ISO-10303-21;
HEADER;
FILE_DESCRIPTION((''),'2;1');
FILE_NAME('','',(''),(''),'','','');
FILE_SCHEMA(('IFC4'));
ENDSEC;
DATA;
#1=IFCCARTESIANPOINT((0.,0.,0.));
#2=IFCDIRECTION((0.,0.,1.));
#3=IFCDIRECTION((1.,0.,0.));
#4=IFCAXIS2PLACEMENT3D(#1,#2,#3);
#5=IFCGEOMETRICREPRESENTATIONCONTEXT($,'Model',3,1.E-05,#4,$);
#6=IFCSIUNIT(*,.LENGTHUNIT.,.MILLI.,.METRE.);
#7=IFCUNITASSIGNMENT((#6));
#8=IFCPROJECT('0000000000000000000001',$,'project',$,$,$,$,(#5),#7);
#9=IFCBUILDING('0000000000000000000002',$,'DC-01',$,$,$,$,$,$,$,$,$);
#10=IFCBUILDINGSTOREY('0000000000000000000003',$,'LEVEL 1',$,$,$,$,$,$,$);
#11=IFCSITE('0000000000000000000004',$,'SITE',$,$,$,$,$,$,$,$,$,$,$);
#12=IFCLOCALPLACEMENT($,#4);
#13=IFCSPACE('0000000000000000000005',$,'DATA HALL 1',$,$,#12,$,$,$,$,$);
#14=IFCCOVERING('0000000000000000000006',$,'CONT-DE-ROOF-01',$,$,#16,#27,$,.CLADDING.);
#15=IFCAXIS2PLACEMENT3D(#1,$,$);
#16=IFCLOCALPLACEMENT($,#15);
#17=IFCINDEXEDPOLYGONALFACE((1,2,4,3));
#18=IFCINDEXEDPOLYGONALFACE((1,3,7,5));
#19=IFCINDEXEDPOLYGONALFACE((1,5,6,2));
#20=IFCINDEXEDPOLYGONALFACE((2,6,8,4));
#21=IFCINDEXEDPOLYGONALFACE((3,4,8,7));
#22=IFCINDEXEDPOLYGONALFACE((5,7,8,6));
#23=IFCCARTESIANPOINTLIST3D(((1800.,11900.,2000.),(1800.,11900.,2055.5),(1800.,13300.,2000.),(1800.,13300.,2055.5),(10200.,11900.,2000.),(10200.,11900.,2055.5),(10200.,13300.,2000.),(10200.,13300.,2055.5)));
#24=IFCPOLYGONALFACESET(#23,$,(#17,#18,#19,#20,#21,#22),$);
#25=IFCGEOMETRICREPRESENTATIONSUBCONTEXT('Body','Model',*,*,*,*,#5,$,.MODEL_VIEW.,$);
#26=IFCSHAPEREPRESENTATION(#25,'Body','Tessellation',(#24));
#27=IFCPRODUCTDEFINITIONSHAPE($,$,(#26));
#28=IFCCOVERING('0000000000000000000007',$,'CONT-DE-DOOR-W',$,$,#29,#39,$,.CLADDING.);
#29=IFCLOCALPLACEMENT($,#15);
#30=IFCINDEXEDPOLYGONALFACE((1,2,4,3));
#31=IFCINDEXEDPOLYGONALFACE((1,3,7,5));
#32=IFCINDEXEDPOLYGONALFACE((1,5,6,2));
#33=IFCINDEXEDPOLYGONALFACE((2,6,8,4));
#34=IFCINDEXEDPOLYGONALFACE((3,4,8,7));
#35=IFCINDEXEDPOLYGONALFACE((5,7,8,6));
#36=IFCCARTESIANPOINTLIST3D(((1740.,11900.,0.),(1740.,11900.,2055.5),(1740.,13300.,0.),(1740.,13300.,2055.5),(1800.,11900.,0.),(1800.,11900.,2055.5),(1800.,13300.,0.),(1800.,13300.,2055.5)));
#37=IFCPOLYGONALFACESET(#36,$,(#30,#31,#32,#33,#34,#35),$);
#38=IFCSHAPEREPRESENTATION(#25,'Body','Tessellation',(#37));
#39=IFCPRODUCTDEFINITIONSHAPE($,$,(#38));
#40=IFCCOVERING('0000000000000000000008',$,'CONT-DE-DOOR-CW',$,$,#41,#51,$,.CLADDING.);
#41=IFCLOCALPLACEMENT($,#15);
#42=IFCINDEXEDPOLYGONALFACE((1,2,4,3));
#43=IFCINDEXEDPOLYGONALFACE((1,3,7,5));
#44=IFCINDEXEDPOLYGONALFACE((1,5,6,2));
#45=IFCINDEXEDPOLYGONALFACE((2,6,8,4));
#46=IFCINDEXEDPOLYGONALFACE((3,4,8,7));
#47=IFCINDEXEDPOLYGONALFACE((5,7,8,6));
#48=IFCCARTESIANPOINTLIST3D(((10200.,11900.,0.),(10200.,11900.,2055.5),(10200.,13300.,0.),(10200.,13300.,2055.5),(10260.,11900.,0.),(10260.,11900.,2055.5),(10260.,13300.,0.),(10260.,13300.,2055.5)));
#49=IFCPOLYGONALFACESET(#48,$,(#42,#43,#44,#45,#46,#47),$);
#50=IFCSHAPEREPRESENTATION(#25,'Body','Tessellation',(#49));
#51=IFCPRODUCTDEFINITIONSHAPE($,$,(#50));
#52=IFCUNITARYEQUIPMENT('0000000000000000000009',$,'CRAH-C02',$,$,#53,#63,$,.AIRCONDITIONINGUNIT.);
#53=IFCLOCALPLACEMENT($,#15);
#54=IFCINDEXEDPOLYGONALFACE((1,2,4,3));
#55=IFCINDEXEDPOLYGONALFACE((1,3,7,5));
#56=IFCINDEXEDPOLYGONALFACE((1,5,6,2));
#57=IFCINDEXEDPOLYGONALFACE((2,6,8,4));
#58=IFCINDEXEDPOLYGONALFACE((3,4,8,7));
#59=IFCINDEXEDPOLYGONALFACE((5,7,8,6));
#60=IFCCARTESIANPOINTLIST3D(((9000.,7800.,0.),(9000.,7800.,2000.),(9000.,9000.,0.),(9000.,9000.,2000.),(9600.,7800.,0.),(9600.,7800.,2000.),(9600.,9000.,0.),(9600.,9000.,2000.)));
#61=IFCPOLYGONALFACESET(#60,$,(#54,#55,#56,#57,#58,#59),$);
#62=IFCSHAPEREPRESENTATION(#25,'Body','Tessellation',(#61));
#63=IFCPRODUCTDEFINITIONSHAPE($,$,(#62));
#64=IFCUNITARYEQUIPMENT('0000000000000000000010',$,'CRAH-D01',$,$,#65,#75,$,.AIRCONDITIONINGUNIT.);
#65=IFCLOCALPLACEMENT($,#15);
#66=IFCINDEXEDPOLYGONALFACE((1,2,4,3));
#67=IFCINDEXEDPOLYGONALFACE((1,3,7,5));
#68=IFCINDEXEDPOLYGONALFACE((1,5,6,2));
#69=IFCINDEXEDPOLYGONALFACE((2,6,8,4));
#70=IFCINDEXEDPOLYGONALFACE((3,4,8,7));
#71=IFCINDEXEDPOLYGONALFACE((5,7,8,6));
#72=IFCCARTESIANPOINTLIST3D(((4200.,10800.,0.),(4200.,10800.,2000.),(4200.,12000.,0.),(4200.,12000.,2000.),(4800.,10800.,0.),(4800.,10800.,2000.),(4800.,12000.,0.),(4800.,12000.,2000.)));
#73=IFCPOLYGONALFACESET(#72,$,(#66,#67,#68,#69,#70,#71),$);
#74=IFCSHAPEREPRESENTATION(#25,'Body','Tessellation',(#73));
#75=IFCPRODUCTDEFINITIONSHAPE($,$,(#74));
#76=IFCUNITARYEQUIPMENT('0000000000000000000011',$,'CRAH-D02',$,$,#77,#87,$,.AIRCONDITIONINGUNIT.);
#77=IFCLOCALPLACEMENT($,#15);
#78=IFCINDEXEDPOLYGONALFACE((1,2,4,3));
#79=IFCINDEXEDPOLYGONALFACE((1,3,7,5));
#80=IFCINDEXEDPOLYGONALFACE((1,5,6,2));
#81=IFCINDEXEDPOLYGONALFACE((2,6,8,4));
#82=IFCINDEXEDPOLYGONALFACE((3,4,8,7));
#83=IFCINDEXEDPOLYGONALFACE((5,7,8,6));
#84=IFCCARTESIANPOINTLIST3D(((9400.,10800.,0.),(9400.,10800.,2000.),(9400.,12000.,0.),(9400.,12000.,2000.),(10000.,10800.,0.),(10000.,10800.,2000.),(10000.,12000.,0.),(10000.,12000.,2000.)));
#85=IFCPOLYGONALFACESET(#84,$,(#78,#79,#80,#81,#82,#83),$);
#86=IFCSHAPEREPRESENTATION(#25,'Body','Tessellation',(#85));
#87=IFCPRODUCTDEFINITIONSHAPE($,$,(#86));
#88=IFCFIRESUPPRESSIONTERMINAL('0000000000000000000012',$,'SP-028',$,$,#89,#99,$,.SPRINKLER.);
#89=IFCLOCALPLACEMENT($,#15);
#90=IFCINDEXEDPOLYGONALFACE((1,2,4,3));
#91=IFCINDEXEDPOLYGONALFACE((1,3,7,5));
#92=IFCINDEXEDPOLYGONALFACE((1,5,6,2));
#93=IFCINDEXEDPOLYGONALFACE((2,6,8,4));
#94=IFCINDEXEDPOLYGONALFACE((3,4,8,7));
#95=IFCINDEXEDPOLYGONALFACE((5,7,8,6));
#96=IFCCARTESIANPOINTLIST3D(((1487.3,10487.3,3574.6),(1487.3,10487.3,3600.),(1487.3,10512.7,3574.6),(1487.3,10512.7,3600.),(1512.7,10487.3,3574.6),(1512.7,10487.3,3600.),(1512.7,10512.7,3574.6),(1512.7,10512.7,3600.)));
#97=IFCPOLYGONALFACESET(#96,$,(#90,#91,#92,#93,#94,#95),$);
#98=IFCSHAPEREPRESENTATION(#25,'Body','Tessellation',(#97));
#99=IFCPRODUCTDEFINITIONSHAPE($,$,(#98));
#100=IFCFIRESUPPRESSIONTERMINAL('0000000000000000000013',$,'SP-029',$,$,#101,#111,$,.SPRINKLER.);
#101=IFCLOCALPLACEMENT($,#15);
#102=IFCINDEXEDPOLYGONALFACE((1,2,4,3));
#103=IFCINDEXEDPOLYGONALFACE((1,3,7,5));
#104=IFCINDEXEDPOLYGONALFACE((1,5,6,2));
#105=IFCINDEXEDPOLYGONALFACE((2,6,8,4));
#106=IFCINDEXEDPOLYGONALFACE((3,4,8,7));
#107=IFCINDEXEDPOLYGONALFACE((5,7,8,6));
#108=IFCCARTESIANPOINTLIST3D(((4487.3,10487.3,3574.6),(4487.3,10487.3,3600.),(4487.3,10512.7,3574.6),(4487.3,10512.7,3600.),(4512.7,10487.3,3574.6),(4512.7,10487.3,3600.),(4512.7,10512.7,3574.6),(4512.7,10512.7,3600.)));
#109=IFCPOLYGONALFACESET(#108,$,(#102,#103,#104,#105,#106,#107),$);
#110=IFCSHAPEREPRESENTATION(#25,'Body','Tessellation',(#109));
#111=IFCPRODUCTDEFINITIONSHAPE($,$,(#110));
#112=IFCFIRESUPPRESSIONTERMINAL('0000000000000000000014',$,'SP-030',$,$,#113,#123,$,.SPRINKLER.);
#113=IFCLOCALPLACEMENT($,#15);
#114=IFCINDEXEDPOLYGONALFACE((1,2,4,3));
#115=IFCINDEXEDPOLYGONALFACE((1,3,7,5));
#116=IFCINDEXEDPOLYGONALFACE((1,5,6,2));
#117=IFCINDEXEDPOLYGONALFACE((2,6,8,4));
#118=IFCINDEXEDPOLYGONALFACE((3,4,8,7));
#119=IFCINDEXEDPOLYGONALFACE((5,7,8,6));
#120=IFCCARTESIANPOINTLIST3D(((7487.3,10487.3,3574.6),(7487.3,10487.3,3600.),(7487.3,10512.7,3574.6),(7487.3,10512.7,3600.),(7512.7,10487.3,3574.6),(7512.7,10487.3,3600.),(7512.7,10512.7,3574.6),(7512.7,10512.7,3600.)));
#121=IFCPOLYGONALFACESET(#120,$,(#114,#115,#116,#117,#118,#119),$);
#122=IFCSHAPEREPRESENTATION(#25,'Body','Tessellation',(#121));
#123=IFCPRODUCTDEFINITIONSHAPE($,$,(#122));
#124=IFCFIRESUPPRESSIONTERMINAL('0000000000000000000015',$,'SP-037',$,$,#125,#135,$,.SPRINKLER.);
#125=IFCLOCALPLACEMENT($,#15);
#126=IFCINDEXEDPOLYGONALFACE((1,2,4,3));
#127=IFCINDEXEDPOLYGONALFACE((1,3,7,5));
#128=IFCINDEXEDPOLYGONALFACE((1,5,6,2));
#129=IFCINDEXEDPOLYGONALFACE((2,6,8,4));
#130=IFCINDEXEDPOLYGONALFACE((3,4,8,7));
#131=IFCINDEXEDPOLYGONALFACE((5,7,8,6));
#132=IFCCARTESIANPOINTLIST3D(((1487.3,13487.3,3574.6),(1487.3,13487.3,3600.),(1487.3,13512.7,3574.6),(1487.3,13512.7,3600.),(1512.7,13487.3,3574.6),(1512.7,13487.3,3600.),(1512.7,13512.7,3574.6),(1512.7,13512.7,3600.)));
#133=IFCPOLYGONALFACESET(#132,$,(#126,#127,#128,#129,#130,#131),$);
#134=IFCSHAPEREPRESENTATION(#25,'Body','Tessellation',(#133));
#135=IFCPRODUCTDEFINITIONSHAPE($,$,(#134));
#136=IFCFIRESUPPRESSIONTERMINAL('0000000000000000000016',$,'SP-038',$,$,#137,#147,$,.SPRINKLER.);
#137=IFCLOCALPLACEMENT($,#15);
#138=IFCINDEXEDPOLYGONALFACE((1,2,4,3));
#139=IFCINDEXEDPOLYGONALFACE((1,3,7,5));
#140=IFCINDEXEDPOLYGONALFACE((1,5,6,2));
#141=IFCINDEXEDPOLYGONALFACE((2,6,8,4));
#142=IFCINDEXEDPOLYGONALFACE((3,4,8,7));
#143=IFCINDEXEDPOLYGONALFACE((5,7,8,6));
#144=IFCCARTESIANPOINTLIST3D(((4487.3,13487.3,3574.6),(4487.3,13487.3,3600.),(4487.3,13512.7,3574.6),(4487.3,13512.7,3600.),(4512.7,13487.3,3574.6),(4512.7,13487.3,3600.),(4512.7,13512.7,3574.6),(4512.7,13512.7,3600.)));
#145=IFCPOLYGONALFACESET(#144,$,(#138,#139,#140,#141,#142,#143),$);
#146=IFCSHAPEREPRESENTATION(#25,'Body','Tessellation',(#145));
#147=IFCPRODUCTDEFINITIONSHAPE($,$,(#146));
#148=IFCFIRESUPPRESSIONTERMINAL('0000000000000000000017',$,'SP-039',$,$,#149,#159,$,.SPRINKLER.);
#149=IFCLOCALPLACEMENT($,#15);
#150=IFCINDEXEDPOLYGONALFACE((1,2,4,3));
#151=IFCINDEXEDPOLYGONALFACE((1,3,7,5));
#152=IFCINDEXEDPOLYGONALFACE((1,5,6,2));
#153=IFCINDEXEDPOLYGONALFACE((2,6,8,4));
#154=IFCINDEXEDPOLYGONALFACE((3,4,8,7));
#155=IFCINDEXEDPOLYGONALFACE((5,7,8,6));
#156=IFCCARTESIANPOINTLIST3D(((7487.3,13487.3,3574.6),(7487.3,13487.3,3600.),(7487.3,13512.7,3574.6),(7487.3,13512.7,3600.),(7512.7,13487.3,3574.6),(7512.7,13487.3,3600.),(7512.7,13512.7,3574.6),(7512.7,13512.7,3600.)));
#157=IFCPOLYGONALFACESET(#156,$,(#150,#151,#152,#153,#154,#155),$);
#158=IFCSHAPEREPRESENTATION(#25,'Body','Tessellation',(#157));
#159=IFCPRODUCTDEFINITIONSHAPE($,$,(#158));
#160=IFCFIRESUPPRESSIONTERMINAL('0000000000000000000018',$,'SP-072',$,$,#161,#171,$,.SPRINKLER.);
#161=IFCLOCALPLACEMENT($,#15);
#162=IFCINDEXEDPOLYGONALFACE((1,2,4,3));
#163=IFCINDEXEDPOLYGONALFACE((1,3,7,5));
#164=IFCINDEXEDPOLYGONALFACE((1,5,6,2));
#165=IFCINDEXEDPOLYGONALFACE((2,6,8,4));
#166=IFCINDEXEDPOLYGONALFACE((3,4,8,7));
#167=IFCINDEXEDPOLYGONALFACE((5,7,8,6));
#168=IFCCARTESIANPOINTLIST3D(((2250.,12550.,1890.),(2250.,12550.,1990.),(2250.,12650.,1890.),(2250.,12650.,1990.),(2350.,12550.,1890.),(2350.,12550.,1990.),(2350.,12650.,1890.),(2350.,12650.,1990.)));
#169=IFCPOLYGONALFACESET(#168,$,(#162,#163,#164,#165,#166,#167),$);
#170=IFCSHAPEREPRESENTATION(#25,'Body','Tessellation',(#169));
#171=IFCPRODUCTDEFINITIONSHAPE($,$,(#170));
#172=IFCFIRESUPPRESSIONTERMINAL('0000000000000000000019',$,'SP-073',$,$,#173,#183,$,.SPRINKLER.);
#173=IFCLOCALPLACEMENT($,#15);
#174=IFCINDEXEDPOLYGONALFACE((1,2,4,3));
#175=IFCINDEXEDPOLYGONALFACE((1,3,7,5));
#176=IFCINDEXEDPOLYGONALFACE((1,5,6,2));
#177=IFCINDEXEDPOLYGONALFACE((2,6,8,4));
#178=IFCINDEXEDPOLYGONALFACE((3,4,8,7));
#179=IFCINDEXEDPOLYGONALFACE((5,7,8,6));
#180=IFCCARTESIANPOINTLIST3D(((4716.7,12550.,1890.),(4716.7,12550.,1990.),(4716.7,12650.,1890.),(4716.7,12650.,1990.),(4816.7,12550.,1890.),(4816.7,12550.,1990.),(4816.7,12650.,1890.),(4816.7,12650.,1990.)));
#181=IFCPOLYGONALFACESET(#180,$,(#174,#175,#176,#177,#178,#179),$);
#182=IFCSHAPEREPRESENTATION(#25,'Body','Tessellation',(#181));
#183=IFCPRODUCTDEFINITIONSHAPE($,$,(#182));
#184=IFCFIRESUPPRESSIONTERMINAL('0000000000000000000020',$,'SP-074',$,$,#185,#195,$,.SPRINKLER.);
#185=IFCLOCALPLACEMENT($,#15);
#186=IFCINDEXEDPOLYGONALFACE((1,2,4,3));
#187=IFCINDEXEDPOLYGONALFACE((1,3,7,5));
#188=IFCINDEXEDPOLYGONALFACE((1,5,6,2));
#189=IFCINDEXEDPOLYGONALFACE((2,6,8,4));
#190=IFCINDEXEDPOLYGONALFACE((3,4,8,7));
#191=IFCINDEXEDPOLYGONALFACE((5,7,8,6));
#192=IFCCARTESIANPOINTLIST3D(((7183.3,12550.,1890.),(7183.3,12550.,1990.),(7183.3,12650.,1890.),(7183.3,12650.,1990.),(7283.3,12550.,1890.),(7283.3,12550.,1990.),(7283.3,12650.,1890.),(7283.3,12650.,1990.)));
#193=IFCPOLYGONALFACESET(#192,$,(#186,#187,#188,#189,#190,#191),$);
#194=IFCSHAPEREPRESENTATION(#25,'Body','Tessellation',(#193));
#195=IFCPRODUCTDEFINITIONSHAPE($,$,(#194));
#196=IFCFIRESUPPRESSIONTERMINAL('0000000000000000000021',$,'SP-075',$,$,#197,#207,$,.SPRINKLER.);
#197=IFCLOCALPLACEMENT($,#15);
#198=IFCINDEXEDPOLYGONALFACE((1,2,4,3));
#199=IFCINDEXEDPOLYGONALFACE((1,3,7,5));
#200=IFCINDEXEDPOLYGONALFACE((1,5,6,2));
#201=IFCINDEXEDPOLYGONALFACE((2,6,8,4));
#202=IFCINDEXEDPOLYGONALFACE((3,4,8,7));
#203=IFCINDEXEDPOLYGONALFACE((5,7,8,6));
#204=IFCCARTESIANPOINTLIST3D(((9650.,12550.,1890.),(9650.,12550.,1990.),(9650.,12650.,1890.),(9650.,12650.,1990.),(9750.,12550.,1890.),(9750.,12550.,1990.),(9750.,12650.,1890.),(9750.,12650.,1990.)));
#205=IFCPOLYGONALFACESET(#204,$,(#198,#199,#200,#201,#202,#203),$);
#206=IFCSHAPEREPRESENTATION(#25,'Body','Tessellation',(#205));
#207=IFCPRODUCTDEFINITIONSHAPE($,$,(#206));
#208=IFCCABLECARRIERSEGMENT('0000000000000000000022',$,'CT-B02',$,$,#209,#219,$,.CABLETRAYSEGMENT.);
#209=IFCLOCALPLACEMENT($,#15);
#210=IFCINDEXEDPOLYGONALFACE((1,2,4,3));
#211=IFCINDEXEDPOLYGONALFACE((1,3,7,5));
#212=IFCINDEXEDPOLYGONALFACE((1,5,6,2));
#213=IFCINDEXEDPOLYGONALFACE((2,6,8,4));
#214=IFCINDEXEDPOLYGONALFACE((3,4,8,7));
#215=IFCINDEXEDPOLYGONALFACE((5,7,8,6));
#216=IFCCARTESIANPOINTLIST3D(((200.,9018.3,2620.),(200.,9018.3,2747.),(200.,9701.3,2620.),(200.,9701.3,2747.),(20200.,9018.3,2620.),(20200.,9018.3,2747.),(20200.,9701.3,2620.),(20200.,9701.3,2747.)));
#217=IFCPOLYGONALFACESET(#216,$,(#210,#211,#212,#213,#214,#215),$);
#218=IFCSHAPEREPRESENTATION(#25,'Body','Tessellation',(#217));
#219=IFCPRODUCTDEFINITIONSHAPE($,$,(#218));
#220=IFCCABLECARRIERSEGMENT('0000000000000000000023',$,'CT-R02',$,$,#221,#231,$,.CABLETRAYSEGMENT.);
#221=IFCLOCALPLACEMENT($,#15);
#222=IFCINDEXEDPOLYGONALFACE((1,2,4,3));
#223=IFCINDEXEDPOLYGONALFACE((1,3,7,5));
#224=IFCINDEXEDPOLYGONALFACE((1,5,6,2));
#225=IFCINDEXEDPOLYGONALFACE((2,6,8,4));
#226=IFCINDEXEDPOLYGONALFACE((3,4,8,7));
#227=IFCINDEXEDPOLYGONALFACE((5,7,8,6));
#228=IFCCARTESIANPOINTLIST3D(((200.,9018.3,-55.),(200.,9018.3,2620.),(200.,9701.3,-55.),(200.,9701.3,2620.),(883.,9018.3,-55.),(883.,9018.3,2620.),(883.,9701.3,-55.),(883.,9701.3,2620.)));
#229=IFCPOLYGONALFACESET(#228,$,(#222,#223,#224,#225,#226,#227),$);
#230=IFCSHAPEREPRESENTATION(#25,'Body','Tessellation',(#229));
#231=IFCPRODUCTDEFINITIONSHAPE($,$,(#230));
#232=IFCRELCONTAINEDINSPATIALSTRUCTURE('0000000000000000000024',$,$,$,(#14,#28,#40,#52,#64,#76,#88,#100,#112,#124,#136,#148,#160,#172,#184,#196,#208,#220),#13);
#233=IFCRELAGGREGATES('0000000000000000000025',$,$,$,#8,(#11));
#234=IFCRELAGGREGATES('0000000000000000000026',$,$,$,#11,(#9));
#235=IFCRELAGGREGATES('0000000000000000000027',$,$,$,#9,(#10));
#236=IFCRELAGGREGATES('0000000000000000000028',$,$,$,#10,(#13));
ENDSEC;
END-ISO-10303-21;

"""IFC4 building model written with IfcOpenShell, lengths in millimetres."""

from ifc_helpers import new_model, si_unit, frame, origin, origin_with_axes, place, context, subcontext, project, spatial, polyline, outline, extrude, element, save


model = new_model("IFC4")

# Units and contexts
model_context = context("Model", 3, precision=1e-05, world=origin_with_axes())
body_context = subcontext(model_context, "Body", "Model", "MODEL_VIEW")
ifc_project = project(units=[si_unit("LENGTHUNIT", "METRE", prefix="MILLI")], contexts=[model_context])

# Site, building, storey, space
site = spatial("IfcSite", under=ifc_project, Name="SITE")
building = spatial("IfcBuilding", under=site, Name="DC-01")
storey = spatial("IfcBuildingStorey", under=building, Name="LEVEL 1")
space_placement = place(None, origin_with_axes())
space = spatial("IfcSpace", under=storey, at=space_placement, Name="DATA HALL 1")

# Coverings
covering_placement = place(space_placement, frame((1800.0, 11900.0, 2000.0), z_axis=(0.0, 0.0, 1.0), x_axis=(1.0, 0.0, 0.0)))
element("IfcCovering", 1, at=covering_placement, inside=space, Name="CONT-DE-ROOF-01", PredefinedType="CLADDING", context=body_context, shape_type="SweptSolid", body=[
    extrude(outline(polyline([(0.0, 0.0), (8400.0, 0.0), (8400.0, 1400.0), (0.0, 1400.0), (0.0, 0.0)])), origin(), (0.0, 0.0, 1.0), 55.5),
])
for number, where, z_axis, x_axis, name in (
    (2, (1740.0, 11900.0, 0.0), (0.0, 0.0, 1.0), (1.0, 0.0, 0.0), "CONT-DE-DOOR-W"),
    (3, (10200.0, 11900.0, 0.0), (0.0, 0.0, 1.0), (1.0, 0.0, 0.0), "CONT-DE-DOOR-CW"),
):
    element("IfcCovering", number, at=place(space_placement, frame(where, z_axis=z_axis, x_axis=x_axis)), inside=space, Name=name, PredefinedType="CLADDING", context=body_context, shape_type="SweptSolid", body=[
        extrude(outline(polyline([(0.0, 0.0), (60.0, 0.0), (60.0, 1400.0), (0.0, 1400.0), (0.0, 0.0)])), origin(), (0.0, 0.0, 1.0), 2055.5),
    ])

# Unitary equipment
for number, where, z_axis, x_axis, name in (
    (4, (9600.0, 9000.0, 0.0), (0.0, 0.0, 1.0), (-1.0, 0.0, 0.0), "CRAH-C02"),
    (5, (4200.0, 10800.0, 0.0), (0.0, 0.0, 1.0), (1.0, 0.0, 0.0), "CRAH-D01"),
    (6, (9400.0, 10800.0, 0.0), (0.0, 0.0, 1.0), (1.0, 0.0, 0.0), "CRAH-D02"),
):
    element("IfcUnitaryEquipment", number, at=place(space_placement, frame(where, z_axis=z_axis, x_axis=x_axis)), inside=space, Name=name, PredefinedType="AIRCONDITIONINGUNIT", context=body_context, shape_type="SweptSolid", body=[
        extrude(outline(polyline([(0.0, 0.0), (600.0, 0.0), (600.0, 1200.0), (0.0, 1200.0), (0.0, 0.0)])), origin(), (0.0, 0.0, 1.0), 2000.0),
    ])

# Fire suppression terminals
for number, where, z_axis, x_axis, name in (
    (7, (1487.3, 10487.3, 3574.6), (0.0, 0.0, 1.0), (1.0, 0.0, 0.0), "SP-028"),
    (8, (4487.3, 10487.3, 3574.6), (0.0, 0.0, 1.0), (1.0, 0.0, 0.0), "SP-029"),
    (9, (7487.3, 10487.3, 3574.6), (0.0, 0.0, 1.0), (1.0, 0.0, 0.0), "SP-030"),
    (10, (1487.3, 13487.3, 3574.6), (0.0, 0.0, 1.0), (1.0, 0.0, 0.0), "SP-037"),
    (11, (4487.3, 13487.3, 3574.6), (0.0, 0.0, 1.0), (1.0, 0.0, 0.0), "SP-038"),
    (12, (7487.3, 13487.3, 3574.6), (0.0, 0.0, 1.0), (1.0, 0.0, 0.0), "SP-039"),
):
    element("IfcFireSuppressionTerminal", number, at=place(space_placement, frame(where, z_axis=z_axis, x_axis=x_axis)), inside=space, Name=name, PredefinedType="SPRINKLER", context=body_context, shape_type="SweptSolid", body=[
        extrude(outline(polyline([(0.0, 0.0), (25.4, 0.0), (25.4, 25.4), (0.0, 25.4), (0.0, 0.0)])), origin(), (0.0, 0.0, 1.0), 25.4),
    ])
for number, where, z_axis, x_axis, name in (
    (13, (2250.0, 12550.0, 1890.0), (0.0, 0.0, 1.0), (1.0, 0.0, 0.0), "SP-072"),
    (14, (4716.7, 12550.0, 1890.0), (0.0, 0.0, 1.0), (1.0, 0.0, 0.0), "SP-073"),
    (15, (7183.3, 12550.0, 1890.0), (0.0, 0.0, 1.0), (1.0, 0.0, 0.0), "SP-074"),
    (16, (9650.0, 12550.0, 1890.0), (0.0, 0.0, 1.0), (1.0, 0.0, 0.0), "SP-075"),
):
    element("IfcFireSuppressionTerminal", number, at=place(space_placement, frame(where, z_axis=z_axis, x_axis=x_axis)), inside=space, Name=name, PredefinedType="SPRINKLER", context=body_context, shape_type="SweptSolid", body=[
        extrude(outline(polyline([(0.0, 0.0), (100.0, 0.0), (100.0, 100.0), (0.0, 100.0), (0.0, 0.0)])), origin(), (0.0, 0.0, 1.0), 100.0),
    ])

# Cable carrier segments
cable_carrier_segment_1_placement = place(space_placement, frame((200.0, 9018.3, 2620.0), z_axis=(0.0, 0.0, 1.0), x_axis=(1.0, 0.0, 0.0)))
element("IfcCableCarrierSegment", 17, at=cable_carrier_segment_1_placement, inside=space, Name="CT-B02", PredefinedType="CABLETRAYSEGMENT", context=body_context, shape_type="SweptSolid", body=[
    extrude(outline(polyline([(0.0, 0.0), (20000.0, 0.0), (20000.0, 683.0), (0.0, 683.0), (0.0, 0.0)])), origin(), (0.0, 0.0, 1.0), 127.0),
])
cable_carrier_segment_2_placement = place(space_placement, frame((200.0, 9018.3, -55.0), z_axis=(0.0, 0.0, 1.0), x_axis=(1.0, 0.0, 0.0)))
element("IfcCableCarrierSegment", 18, at=cable_carrier_segment_2_placement, inside=space, Name="CT-R02", PredefinedType="CABLETRAYSEGMENT", context=body_context, shape_type="SweptSolid", body=[
    extrude(outline(polyline([(0.0, 0.0), (683.0, 0.0), (683.0, 683.0), (0.0, 683.0), (0.0, 0.0)])), origin(), (0.0, 0.0, 1.0), 2675.0),
])

save(model, "model.ifc")
